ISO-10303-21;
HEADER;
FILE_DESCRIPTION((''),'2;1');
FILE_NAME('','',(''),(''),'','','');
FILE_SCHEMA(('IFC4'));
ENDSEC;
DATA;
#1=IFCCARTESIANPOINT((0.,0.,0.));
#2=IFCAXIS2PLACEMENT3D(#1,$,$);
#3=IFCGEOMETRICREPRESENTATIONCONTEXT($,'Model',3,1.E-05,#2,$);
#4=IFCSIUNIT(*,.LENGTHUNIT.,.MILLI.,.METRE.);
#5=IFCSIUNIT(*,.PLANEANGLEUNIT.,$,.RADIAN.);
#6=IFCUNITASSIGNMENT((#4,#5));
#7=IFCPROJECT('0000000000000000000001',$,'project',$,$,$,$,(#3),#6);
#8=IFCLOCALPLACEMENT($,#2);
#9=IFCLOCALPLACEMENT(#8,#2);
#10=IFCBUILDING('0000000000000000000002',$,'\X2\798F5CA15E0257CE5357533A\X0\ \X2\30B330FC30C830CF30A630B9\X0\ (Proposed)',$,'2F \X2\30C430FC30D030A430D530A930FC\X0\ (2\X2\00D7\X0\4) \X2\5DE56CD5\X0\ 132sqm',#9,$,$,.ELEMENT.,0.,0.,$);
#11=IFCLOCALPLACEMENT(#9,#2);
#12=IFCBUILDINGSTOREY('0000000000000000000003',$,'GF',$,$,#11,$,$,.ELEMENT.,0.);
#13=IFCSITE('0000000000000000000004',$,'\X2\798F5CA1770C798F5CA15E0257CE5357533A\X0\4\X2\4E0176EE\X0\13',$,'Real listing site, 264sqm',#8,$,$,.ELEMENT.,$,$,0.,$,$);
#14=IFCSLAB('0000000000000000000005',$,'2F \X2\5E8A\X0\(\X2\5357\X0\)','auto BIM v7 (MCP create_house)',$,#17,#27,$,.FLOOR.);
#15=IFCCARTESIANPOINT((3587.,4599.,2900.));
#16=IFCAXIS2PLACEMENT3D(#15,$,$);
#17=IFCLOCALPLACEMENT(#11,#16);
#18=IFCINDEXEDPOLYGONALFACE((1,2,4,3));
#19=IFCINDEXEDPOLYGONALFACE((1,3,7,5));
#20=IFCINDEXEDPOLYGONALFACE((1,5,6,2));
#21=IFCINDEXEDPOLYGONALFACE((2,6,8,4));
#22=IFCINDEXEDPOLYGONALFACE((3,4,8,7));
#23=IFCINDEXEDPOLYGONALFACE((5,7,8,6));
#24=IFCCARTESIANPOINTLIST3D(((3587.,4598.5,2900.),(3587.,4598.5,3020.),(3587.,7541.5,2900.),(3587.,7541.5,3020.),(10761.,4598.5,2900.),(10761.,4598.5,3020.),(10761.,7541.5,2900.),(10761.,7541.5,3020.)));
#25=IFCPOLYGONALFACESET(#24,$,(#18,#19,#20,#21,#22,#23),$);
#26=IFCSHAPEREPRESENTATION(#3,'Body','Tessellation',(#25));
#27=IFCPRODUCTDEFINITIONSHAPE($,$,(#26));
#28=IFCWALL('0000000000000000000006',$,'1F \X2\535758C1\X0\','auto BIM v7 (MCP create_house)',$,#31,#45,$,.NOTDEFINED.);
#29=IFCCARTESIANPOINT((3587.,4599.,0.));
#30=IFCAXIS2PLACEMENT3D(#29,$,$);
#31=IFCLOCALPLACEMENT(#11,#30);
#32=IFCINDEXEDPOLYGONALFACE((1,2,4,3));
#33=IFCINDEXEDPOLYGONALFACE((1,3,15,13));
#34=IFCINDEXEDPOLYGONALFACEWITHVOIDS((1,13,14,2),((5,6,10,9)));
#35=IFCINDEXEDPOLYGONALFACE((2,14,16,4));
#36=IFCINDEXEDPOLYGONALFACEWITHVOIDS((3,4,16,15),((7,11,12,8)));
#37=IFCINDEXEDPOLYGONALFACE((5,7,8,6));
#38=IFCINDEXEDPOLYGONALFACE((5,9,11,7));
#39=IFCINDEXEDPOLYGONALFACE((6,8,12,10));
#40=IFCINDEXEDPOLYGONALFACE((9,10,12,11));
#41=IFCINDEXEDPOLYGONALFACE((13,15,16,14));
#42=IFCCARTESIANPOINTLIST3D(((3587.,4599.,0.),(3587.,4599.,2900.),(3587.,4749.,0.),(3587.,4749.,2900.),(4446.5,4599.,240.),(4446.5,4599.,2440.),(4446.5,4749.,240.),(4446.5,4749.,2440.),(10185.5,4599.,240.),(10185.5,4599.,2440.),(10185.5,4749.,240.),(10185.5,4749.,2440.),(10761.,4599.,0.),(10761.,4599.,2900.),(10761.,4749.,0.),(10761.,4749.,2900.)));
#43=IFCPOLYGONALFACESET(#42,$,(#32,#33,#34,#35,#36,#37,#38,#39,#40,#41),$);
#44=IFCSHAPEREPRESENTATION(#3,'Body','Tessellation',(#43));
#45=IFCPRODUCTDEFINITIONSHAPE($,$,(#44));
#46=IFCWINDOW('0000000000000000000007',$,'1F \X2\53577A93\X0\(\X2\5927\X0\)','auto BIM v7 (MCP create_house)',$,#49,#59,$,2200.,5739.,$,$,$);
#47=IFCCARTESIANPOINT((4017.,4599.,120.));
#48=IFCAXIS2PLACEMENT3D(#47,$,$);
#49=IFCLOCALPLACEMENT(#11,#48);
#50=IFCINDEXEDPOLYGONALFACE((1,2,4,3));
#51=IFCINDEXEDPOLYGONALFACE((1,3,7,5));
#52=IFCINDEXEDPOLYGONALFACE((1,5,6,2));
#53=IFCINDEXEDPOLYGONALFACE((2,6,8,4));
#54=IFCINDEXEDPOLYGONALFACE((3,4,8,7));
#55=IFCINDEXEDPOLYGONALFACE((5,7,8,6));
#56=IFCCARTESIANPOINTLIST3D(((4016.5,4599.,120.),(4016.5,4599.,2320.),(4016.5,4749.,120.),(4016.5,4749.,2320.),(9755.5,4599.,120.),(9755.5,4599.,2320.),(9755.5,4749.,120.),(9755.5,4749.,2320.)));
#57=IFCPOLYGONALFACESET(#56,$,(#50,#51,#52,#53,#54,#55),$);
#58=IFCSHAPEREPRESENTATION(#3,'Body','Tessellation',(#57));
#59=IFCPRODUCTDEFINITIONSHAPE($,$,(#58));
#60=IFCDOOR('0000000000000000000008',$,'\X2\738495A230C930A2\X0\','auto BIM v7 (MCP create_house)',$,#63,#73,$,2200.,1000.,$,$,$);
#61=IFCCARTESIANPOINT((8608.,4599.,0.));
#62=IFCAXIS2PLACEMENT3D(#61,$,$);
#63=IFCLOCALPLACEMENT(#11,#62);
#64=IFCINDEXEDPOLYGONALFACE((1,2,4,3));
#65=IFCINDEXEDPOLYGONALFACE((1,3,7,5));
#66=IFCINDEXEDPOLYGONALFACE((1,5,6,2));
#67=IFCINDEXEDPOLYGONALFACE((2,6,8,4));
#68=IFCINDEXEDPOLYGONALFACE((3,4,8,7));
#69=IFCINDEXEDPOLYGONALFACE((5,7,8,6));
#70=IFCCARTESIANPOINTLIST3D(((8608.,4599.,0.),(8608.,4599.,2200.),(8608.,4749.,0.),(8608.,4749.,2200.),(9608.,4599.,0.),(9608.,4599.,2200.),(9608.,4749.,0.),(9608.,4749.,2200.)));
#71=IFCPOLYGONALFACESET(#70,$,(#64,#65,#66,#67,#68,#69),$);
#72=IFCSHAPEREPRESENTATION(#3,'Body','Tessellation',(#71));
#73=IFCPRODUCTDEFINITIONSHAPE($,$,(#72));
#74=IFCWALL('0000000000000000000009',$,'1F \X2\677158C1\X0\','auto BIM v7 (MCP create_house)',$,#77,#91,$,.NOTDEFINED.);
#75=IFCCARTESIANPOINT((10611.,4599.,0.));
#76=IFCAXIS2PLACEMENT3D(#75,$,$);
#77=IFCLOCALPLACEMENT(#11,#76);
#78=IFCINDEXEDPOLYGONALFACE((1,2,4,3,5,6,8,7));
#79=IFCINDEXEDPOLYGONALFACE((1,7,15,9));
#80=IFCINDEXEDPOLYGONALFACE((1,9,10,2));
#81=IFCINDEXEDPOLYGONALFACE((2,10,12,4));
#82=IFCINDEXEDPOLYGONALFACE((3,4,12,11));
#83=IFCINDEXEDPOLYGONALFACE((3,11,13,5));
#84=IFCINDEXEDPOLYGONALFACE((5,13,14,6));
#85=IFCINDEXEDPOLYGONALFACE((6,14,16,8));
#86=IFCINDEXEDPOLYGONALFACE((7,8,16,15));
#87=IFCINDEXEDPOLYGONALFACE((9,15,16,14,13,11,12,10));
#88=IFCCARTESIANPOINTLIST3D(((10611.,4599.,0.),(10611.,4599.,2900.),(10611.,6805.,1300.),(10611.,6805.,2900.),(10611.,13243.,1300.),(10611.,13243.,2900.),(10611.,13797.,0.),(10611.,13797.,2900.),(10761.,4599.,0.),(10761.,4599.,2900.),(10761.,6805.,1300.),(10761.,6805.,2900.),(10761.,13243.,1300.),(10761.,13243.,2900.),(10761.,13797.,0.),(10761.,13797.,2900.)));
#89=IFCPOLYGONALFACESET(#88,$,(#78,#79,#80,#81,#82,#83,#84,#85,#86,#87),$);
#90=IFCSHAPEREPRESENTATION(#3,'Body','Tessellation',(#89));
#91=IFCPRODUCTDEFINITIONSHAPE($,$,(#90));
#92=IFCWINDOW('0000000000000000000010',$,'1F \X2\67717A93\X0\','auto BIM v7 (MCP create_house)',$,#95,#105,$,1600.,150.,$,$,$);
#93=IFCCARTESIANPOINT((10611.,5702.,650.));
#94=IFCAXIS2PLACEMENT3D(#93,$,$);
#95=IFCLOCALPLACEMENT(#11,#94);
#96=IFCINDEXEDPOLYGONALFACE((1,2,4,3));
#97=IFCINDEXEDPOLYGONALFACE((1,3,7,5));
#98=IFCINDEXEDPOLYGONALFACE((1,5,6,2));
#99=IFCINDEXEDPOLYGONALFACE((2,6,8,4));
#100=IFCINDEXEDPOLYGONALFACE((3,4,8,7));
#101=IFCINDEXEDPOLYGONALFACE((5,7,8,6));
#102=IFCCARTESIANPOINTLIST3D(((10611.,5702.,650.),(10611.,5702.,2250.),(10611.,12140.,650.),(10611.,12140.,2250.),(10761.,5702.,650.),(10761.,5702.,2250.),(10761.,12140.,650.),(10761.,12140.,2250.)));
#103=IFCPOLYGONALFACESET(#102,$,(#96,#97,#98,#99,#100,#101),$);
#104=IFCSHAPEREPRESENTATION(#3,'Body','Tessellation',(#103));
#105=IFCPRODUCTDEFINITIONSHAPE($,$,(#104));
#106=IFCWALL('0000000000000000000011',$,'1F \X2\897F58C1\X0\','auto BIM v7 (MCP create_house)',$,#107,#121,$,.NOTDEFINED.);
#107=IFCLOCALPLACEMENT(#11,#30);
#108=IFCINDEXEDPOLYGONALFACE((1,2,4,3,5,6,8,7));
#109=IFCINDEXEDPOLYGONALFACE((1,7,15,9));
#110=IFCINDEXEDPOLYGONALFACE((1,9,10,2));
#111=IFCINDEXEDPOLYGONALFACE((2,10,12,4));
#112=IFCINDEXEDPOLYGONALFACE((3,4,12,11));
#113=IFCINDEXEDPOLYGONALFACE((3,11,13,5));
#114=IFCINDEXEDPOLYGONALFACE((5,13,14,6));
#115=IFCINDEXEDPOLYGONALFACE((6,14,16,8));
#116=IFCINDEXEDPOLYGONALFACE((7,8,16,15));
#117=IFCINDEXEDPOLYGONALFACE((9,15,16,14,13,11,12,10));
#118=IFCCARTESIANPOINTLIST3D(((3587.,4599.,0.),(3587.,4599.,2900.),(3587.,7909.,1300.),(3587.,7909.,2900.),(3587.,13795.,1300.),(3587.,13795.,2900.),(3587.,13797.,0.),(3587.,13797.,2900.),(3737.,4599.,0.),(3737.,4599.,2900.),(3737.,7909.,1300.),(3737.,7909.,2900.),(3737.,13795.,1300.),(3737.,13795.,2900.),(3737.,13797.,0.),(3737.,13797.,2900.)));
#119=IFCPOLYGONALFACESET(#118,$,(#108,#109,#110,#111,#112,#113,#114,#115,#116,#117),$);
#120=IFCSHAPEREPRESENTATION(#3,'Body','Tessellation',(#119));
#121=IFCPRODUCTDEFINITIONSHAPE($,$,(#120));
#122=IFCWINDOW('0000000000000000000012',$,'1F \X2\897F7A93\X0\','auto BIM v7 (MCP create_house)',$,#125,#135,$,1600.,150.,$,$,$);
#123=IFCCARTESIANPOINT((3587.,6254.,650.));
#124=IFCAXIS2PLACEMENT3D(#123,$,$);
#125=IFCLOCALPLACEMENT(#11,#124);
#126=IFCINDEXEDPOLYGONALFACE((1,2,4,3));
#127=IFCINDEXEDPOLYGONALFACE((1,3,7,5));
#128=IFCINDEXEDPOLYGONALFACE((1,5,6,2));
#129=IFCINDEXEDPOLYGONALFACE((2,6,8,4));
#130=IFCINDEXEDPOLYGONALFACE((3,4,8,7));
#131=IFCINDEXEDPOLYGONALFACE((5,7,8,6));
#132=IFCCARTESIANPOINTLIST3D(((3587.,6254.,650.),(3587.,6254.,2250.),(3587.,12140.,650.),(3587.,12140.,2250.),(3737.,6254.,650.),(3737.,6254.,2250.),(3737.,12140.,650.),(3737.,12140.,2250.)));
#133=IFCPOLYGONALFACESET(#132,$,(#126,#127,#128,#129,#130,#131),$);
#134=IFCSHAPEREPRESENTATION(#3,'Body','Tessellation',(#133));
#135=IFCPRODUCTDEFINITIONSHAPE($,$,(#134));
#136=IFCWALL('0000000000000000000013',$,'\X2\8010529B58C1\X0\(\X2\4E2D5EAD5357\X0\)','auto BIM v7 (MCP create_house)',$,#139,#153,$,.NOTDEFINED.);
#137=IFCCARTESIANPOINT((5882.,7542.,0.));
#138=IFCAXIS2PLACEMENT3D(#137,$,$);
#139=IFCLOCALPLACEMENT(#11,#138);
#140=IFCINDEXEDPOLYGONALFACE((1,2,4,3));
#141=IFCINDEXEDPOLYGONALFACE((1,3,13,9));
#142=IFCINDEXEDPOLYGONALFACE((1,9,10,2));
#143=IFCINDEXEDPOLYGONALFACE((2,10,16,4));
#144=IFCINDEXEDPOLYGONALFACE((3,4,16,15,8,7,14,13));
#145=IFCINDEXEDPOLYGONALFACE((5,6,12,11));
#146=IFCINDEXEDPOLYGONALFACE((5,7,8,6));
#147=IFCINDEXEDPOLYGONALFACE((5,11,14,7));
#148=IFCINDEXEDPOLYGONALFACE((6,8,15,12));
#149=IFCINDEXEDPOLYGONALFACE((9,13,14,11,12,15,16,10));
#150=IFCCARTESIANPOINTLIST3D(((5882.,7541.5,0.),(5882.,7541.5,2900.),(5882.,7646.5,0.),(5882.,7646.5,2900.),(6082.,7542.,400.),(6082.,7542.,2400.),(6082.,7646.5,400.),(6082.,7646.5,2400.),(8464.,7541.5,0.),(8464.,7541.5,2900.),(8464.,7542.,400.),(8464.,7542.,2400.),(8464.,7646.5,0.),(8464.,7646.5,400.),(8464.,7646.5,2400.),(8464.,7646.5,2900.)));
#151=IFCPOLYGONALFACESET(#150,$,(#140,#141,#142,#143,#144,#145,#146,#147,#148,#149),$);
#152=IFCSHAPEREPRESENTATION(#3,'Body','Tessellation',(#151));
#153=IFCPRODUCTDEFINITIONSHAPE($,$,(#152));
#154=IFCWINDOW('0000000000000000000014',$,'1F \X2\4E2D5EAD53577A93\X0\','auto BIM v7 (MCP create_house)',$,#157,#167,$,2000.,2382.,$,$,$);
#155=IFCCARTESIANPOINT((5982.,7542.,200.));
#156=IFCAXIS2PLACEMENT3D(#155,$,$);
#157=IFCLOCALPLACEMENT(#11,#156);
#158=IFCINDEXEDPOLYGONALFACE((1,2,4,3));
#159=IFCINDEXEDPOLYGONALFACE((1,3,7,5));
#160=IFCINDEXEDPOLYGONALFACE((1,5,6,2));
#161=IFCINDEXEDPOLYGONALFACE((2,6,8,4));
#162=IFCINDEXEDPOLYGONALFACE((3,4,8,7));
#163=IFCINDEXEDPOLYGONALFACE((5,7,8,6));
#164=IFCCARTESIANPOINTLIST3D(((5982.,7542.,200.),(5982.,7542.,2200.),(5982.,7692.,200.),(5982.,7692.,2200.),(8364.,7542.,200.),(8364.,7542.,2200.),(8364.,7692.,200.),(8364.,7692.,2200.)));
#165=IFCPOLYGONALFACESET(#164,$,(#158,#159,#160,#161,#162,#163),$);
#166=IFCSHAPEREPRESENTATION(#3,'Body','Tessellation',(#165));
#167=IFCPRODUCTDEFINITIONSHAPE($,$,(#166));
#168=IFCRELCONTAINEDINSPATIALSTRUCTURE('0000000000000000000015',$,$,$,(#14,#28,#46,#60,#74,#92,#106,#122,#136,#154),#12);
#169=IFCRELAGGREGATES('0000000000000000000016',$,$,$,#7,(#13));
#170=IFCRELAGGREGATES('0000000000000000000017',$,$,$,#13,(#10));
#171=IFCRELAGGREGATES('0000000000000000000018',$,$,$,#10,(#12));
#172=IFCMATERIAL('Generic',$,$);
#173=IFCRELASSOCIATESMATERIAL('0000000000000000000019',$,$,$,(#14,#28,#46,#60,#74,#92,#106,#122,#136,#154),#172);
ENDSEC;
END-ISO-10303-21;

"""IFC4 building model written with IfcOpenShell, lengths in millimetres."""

from ifc_helpers import new_model, si_unit, frame, frame_2d, origin, place, context, project, spatial, rectangle, extrude, material, element, fill, save


model = new_model("IFC4")

# Units and contexts
model_context = context("Model", 3, precision=1e-05, world=origin())
ifc_project = project(units=[si_unit("LENGTHUNIT", "METRE", prefix="MILLI"), si_unit("PLANEANGLEUNIT", "RADIAN")], contexts=[model_context])

# Site, building, storey
site_placement = place(None, origin())
site = spatial("IfcSite", under=ifc_project, at=site_placement, Name="福岡県福岡市城南区4丁目13", ObjectType="Real listing site, 264sqm", CompositionType="ELEMENT", RefElevation=0.0)
building_placement = place(site_placement, origin())
building = spatial("IfcBuilding", under=site, at=building_placement, Name="福岡市城南区 コートハウス (Proposed)", ObjectType="2F ツーバイフォー (2×4) 工法 132sqm", CompositionType="ELEMENT", ElevationOfRefHeight=0.0, ElevationOfTerrain=0.0)
storey_placement = place(building_placement, origin())
storey = spatial("IfcBuildingStorey", under=building, at=storey_placement, Name="GF", CompositionType="ELEMENT", Elevation=0.0)

# Slab
ifc_material = material(Name="Generic")
slab_1_placement = place(storey_placement, frame((3587.0, 4599.0, 2900.0)))
element("IfcSlab", 1, at=slab_1_placement, inside=storey, material=ifc_material, Name="2F 床(南)", Description="auto BIM v7 (MCP create_house)", PredefinedType="FLOOR", context=model_context, shape_type="SweptSolid", body=[
    extrude(rectangle(XDim=7174.0, YDim=2943.0, at=frame_2d((3587.0, 1471.0))), frame((3587.0, 4599.0, 2900.0)), (0.0, 0.0, 1.0), 120.0),
])

# Wall, openings, window, door
wall_1_placement = place(storey_placement, frame((3587.0, 4599.0, 0.0)))
wall_1 = element("IfcWall", 2, at=wall_1_placement, inside=storey, material=ifc_material, Name="1F 南壁", Description="auto BIM v7 (MCP create_house)", PredefinedType="NOTDEFINED", context=model_context, shape_type="SweptSolid", body=[
    extrude(rectangle(XDim=7174.0, YDim=150.0, at=frame_2d((3587.0, 75.0))), frame((3587.0, 4599.0, 0.0)), (0.0, 0.0, 1.0), 2900.0),
])
opening_1_placement = place(storey_placement, frame((4017.0, 4599.0, 120.0)))
opening_1 = element("IfcOpeningElement", 3, at=opening_1_placement, cuts=wall_1, PredefinedType="NOTDEFINED", context=model_context, shape_type="SweptSolid", body=[
    extrude(rectangle(XDim=5739.0, YDim=150.0, at=frame_2d((2869.0, 75.0))), frame((4017.0, 4599.0, 120.0)), (0.0, 0.0, 1.0), 2200.0),
])
opening_2_placement = place(storey_placement, frame((8608.0, 4599.0, 0.0)))
opening_2 = element("IfcOpeningElement", 4, at=opening_2_placement, cuts=wall_1, PredefinedType="NOTDEFINED", context=model_context, shape_type="SweptSolid", body=[
    extrude(rectangle(XDim=1000.0, YDim=150.0, at=frame_2d((500.0, 75.0))), frame((8608.0, 4599.0, 0.0)), (0.0, 0.0, 1.0), 2200.0),
])
window_1_placement = place(storey_placement, frame((4017.0, 4599.0, 120.0)))
window_1 = element("IfcWindow", 5, at=window_1_placement, inside=storey, material=ifc_material, Name="1F 南窓(大)", Description="auto BIM v7 (MCP create_house)", OverallHeight=2200.0, OverallWidth=5739.0, context=model_context, shape_type="SweptSolid", body=[
    extrude(rectangle(XDim=5739.0, YDim=150.0, at=frame_2d((2869.0, 75.0))), frame((4017.0, 4599.0, 120.0)), (0.0, 0.0, 1.0), 2200.0),
])
fill(opening_1, window_1)
door_placement = place(storey_placement, frame((8608.0, 4599.0, 0.0)))
door = element("IfcDoor", 6, at=door_placement, inside=storey, material=ifc_material, Name="玄関ドア", Description="auto BIM v7 (MCP create_house)", OverallHeight=2200.0, OverallWidth=1000.0, context=model_context, shape_type="SweptSolid", body=[
    extrude(rectangle(XDim=1000.0, YDim=150.0, at=frame_2d((500.0, 75.0))), frame((8608.0, 4599.0, 0.0)), (0.0, 0.0, 1.0), 2200.0),
])
fill(opening_2, door)

# Walls, openings, windows
wall_2_placement = place(storey_placement, frame((10611.0, 4599.0, 0.0)))
wall_2 = element("IfcWall", 7, at=wall_2_placement, inside=storey, material=ifc_material, Name="1F 東壁", Description="auto BIM v7 (MCP create_house)", PredefinedType="NOTDEFINED", context=model_context, shape_type="SweptSolid", body=[
    extrude(rectangle(XDim=150.0, YDim=9198.0, at=frame_2d((75.0, 4599.0))), frame((10611.0, 4599.0, 0.0)), (0.0, 0.0, 1.0), 2900.0),
])
opening_3_placement = place(storey_placement, frame((10611.0, 5702.0, 650.0)))
opening_3 = element("IfcOpeningElement", 8, at=opening_3_placement, cuts=wall_2, PredefinedType="NOTDEFINED", context=model_context, shape_type="SweptSolid", body=[
    extrude(rectangle(XDim=150.0, YDim=6438.0, at=frame_2d((75.0, 3219.0))), frame((10611.0, 5702.0, 650.0)), (0.0, 0.0, 1.0), 1600.0),
])
window_2_placement = place(storey_placement, frame((10611.0, 5702.0, 650.0)))
window_2 = element("IfcWindow", 9, at=window_2_placement, inside=storey, material=ifc_material, Name="1F 東窓", Description="auto BIM v7 (MCP create_house)", OverallHeight=1600.0, OverallWidth=150.0, context=model_context, shape_type="SweptSolid", body=[
    extrude(rectangle(XDim=150.0, YDim=6438.0, at=frame_2d((75.0, 3219.0))), frame((10611.0, 5702.0, 650.0)), (0.0, 0.0, 1.0), 1600.0),
])
fill(opening_3, window_2)
wall_3_placement = place(storey_placement, frame((3587.0, 4599.0, 0.0)))
wall_3 = element("IfcWall", 10, at=wall_3_placement, inside=storey, material=ifc_material, Name="1F 西壁", Description="auto BIM v7 (MCP create_house)", PredefinedType="NOTDEFINED", context=model_context, shape_type="SweptSolid", body=[
    extrude(rectangle(XDim=150.0, YDim=9198.0, at=frame_2d((75.0, 4599.0))), frame((3587.0, 4599.0, 0.0)), (0.0, 0.0, 1.0), 2900.0),
])
opening_4_placement = place(storey_placement, frame((3587.0, 6254.0, 650.0)))
opening_4 = element("IfcOpeningElement", 11, at=opening_4_placement, cuts=wall_3, PredefinedType="NOTDEFINED", context=model_context, shape_type="SweptSolid", body=[
    extrude(rectangle(XDim=150.0, YDim=5886.0, at=frame_2d((75.0, 2943.0))), frame((3587.0, 6254.0, 650.0)), (0.0, 0.0, 1.0), 1600.0),
])
window_3_placement = place(storey_placement, frame((3587.0, 6254.0, 650.0)))
window_3 = element("IfcWindow", 12, at=window_3_placement, inside=storey, material=ifc_material, Name="1F 西窓", Description="auto BIM v7 (MCP create_house)", OverallHeight=1600.0, OverallWidth=150.0, context=model_context, shape_type="SweptSolid", body=[
    extrude(rectangle(XDim=150.0, YDim=5886.0, at=frame_2d((75.0, 2943.0))), frame((3587.0, 6254.0, 650.0)), (0.0, 0.0, 1.0), 1600.0),
])
fill(opening_4, window_3)
wall_4_placement = place(storey_placement, frame((5882.0, 7542.0, 0.0)))
wall_4 = element("IfcWall", 13, at=wall_4_placement, inside=storey, material=ifc_material, Name="耐力壁(中庭南)", Description="auto BIM v7 (MCP create_house)", PredefinedType="NOTDEFINED", context=model_context, shape_type="SweptSolid", body=[
    extrude(rectangle(XDim=2582.0, YDim=105.0, at=frame_2d((1291.0, 52.0))), frame((5882.0, 7542.0, 0.0)), (0.0, 0.0, 1.0), 2900.0),
])
opening_5_placement = place(storey_placement, frame((5982.0, 7542.0, 200.0)))
opening_5 = element("IfcOpeningElement", 14, at=opening_5_placement, cuts=wall_4, PredefinedType="NOTDEFINED", context=model_context, shape_type="SweptSolid", body=[
    extrude(rectangle(XDim=2382.0, YDim=150.0, at=frame_2d((1191.0, 75.0))), frame((5982.0, 7542.0, 200.0)), (0.0, 0.0, 1.0), 2000.0),
])
window_4_placement = place(storey_placement, frame((5982.0, 7542.0, 200.0)))
window_4 = element("IfcWindow", 15, at=window_4_placement, inside=storey, material=ifc_material, Name="1F 中庭南窓", Description="auto BIM v7 (MCP create_house)", OverallHeight=2000.0, OverallWidth=2382.0, context=model_context, shape_type="SweptSolid", body=[
    extrude(rectangle(XDim=2382.0, YDim=150.0, at=frame_2d((1191.0, 75.0))), frame((5982.0, 7542.0, 200.0)), (0.0, 0.0, 1.0), 2000.0),
])
fill(opening_5, window_4)

save(model, "model.ifc")
